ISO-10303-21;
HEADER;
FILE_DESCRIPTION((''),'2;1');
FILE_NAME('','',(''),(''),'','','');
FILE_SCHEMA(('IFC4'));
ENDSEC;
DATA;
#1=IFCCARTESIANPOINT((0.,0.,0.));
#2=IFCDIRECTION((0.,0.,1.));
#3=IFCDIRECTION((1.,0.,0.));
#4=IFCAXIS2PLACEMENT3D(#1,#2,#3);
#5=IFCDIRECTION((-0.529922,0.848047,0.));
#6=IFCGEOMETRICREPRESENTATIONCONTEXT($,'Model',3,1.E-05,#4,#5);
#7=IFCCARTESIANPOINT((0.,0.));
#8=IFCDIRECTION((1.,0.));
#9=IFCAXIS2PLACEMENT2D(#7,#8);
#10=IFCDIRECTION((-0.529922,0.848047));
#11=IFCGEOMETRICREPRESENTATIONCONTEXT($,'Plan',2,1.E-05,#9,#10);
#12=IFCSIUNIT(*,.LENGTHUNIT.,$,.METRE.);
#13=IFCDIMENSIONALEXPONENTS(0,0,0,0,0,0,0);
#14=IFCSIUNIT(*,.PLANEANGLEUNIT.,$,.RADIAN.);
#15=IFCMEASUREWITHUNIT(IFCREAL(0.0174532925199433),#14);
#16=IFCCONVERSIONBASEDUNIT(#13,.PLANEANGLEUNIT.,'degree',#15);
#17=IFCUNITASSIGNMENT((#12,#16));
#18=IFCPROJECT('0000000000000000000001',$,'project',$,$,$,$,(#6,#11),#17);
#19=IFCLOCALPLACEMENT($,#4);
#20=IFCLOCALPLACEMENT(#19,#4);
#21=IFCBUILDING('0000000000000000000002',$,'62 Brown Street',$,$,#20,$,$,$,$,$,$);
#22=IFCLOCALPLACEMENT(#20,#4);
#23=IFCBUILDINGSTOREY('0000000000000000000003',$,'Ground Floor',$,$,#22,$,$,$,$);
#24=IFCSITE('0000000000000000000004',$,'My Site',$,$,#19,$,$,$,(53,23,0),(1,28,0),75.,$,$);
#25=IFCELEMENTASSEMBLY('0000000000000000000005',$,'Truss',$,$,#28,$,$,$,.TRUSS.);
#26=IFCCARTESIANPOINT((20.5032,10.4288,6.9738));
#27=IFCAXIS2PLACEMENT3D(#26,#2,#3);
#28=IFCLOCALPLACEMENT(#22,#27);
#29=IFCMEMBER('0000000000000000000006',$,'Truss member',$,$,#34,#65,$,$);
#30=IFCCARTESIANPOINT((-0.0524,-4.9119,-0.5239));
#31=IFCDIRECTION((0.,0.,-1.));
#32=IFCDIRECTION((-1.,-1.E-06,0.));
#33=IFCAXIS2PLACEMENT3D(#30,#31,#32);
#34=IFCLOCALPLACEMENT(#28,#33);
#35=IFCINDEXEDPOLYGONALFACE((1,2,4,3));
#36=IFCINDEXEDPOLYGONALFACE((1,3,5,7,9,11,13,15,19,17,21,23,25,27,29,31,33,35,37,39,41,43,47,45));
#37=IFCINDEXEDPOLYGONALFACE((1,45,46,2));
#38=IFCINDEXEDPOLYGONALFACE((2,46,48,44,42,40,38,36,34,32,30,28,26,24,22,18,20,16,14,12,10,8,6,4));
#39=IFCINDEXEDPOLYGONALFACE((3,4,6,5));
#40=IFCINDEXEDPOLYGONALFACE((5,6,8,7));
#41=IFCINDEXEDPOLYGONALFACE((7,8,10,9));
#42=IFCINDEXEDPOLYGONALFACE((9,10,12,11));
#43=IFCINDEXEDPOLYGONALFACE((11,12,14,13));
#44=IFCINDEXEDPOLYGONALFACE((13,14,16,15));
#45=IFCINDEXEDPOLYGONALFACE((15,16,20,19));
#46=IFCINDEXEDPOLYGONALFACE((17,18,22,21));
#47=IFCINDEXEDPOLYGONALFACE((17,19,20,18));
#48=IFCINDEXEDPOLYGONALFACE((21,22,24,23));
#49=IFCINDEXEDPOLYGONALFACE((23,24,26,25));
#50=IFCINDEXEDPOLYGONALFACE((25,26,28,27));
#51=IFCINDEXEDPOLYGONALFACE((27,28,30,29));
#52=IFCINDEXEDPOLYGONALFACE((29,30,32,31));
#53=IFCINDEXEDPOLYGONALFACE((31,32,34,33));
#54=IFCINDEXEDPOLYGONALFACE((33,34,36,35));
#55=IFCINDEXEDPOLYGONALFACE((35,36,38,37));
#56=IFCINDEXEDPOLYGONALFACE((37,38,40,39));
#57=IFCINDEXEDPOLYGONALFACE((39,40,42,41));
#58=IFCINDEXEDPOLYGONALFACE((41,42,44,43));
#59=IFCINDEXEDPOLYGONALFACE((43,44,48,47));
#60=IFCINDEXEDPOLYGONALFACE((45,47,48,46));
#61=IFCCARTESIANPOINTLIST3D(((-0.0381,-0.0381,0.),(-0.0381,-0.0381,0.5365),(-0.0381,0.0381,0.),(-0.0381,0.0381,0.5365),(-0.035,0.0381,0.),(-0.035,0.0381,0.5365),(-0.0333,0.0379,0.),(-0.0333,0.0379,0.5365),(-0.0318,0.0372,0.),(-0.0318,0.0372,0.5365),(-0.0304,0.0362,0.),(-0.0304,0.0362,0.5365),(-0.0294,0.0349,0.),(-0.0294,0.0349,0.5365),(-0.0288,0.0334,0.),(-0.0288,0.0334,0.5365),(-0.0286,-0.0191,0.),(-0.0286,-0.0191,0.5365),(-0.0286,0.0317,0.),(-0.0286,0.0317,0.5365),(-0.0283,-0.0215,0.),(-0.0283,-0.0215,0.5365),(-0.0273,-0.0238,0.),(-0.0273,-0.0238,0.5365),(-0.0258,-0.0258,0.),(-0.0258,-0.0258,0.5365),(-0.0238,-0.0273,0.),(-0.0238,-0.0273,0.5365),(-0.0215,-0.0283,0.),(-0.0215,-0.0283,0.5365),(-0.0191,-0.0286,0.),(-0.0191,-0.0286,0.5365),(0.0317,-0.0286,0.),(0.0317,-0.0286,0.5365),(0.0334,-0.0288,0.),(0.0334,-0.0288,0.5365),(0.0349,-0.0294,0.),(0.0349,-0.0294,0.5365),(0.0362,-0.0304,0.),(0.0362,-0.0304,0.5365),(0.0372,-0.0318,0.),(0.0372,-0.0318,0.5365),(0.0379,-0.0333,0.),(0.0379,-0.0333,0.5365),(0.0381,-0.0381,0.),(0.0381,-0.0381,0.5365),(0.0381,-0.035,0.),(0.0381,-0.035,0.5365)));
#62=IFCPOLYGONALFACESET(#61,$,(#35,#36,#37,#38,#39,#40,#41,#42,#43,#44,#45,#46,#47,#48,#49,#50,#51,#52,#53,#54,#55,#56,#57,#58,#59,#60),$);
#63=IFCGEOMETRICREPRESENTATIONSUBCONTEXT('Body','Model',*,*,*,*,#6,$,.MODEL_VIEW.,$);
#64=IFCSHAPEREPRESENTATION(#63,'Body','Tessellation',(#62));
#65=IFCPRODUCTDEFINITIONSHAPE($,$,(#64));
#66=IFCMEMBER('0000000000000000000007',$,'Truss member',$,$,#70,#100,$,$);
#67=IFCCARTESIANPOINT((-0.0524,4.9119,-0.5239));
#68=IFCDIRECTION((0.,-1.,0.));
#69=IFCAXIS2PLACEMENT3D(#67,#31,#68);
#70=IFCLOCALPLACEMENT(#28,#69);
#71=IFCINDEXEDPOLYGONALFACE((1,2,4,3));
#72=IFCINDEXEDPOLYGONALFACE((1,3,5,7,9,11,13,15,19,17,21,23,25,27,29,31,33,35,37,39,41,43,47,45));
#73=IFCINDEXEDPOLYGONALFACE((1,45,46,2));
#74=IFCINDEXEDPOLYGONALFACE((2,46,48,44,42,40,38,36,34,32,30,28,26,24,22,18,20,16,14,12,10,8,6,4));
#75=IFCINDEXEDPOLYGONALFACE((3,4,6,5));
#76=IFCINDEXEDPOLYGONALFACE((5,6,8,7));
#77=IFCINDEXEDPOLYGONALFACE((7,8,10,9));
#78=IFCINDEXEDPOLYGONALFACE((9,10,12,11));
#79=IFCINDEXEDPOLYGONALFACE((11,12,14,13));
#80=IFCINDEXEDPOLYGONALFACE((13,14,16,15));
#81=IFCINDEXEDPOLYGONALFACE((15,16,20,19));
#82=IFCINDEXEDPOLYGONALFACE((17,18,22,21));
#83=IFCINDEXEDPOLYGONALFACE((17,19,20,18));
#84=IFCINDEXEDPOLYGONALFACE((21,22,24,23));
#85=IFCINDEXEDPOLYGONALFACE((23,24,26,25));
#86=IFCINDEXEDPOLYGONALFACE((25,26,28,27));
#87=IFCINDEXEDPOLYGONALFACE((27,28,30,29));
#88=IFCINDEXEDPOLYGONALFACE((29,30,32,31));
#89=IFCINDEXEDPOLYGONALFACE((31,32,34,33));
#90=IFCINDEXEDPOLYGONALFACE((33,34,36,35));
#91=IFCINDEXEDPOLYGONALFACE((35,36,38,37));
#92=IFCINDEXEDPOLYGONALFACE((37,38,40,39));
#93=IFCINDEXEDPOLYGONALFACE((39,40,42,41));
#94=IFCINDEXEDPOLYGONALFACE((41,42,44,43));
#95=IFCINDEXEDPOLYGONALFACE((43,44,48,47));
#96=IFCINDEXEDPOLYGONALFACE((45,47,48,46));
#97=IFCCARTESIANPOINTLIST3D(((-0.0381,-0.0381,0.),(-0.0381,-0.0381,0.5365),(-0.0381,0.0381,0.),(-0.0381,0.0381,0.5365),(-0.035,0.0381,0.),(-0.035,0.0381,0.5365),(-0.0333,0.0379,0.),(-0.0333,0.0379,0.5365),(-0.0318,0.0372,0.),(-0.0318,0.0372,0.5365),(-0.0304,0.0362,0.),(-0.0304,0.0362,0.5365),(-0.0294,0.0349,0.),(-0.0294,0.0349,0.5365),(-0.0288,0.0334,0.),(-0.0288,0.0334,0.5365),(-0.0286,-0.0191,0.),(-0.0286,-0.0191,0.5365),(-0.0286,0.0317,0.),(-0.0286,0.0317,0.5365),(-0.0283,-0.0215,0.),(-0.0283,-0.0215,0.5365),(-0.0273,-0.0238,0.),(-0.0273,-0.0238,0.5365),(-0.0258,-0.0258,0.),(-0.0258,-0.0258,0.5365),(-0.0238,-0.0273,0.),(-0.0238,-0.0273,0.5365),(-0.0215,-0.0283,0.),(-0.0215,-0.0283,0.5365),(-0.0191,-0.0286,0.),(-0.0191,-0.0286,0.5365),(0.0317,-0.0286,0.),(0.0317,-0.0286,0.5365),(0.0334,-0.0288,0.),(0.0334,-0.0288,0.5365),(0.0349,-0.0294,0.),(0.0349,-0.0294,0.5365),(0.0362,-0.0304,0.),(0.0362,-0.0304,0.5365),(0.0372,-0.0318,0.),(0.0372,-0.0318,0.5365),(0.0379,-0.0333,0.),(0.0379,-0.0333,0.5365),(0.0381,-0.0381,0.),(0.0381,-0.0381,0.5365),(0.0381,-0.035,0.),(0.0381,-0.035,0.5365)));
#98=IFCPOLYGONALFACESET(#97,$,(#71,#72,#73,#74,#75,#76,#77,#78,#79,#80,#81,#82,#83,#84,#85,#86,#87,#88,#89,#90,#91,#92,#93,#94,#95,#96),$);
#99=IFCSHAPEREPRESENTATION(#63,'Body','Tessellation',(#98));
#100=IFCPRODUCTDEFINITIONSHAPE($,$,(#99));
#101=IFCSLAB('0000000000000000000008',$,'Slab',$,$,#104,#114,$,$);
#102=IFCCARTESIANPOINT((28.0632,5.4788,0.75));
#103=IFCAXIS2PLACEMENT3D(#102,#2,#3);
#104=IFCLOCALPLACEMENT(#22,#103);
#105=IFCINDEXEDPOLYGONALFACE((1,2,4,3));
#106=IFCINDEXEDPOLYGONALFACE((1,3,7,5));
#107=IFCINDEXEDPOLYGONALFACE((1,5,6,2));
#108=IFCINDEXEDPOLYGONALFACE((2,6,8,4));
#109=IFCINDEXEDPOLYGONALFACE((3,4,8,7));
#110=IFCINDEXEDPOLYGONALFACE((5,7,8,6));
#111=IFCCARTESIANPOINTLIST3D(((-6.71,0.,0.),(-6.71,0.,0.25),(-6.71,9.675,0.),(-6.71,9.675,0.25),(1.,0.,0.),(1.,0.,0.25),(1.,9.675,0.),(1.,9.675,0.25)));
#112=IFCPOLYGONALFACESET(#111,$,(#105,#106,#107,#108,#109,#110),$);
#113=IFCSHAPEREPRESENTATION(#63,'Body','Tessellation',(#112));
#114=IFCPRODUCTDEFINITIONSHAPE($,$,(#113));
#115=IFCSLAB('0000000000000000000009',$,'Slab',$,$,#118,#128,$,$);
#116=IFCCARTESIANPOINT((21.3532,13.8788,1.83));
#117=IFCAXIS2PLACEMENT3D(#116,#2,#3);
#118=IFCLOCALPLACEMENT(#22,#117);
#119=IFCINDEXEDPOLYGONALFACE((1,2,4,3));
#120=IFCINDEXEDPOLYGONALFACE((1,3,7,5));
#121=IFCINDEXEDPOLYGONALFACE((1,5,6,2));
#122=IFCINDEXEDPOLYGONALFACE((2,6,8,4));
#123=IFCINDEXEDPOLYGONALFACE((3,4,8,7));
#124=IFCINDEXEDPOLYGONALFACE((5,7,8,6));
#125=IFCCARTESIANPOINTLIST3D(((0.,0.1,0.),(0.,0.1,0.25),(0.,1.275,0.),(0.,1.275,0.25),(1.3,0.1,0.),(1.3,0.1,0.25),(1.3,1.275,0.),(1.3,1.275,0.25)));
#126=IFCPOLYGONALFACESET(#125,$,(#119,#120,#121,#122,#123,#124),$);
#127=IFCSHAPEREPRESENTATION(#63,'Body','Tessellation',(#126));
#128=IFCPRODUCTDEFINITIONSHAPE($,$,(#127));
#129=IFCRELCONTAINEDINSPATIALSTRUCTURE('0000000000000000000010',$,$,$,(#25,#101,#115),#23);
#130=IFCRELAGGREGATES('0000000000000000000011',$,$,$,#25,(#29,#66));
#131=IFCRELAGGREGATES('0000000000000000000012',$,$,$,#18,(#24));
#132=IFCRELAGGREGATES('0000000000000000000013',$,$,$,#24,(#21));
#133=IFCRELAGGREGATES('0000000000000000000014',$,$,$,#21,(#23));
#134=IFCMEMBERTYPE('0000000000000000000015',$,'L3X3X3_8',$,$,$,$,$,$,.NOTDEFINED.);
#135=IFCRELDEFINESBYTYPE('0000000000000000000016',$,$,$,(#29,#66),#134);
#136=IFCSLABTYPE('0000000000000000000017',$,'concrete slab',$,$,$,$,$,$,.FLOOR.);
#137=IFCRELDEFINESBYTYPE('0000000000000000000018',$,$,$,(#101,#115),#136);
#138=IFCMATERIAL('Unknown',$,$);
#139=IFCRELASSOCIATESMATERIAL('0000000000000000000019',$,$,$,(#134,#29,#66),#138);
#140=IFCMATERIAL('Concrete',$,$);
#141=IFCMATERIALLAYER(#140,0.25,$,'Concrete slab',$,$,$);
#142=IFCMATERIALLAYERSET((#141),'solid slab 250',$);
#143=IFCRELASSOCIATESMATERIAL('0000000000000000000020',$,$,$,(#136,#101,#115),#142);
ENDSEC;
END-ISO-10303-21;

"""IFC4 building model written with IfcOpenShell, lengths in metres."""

from ifc_helpers import new_model, entity, si_unit, converted_unit, direction, frame, origin_with_axes, origin_2d_with_axis, place, context, subcontext, project, spatial, indexed_curve, l_section, outline, extrude, material, layer, layer_set, layer_usage, material_profile, profile_set, profile_usage, type_object, element, aggregate, save


model = new_model("IFC4")

# Units and contexts
model_context = context("Model", 3, precision=1e-05, world=origin_with_axes(), true_north=direction((-0.529922, 0.848047, 0.0)))
plan_context = context("Plan", 2, precision=1e-05, world=origin_2d_with_axis(), true_north=direction((-0.529922, 0.848047)))
body_context = subcontext(model_context, "Body", "Model", "MODEL_VIEW")
ifc_project = project(units=[si_unit("LENGTHUNIT", "METRE"), converted_unit("PLANEANGLEUNIT", "degree", entity("IfcReal", 0.0174532925199433), si_unit("PLANEANGLEUNIT", "RADIAN"), dimensions=[0, 0, 0, 0, 0, 0, 0])], contexts=[model_context, plan_context])

# Site, building, storey
site_placement = place(None, origin_with_axes())
site = spatial("IfcSite", under=ifc_project, at=site_placement, Name="My Site", RefLatitude=(53, 23, 0), RefLongitude=(1, 28, 0), RefElevation=75.0)
building_placement = place(site_placement, origin_with_axes())
building = spatial("IfcBuilding", under=site, at=building_placement, Name="62 Brown Street")
storey_placement = place(building_placement, origin_with_axes())
storey = spatial("IfcBuildingStorey", under=building, at=storey_placement, Name="Ground Floor")

# Shared definitions
ifc_material_1 = material(Name="Concrete")

# Element assembly, members
assembly_placement = place(storey_placement, frame((20.5032, 10.4288, 6.9738), z_axis=(0.0, 0.0, 1.0), x_axis=(1.0, 0.0, 0.0)))
assembly = element("IfcElementAssembly", 1, at=assembly_placement, inside=storey, Name="Truss", PredefinedType="TRUSS")
ifc_material_2 = material(Name="Unknown")
ifc_material_profile_1 = material_profile(ifc_material_2, l_section(Depth=0.0762, Width=0.0762, Thickness=0.0095, FilletRadius=0.0095, EdgeRadius=0.0064))
ifc_profile_set_1 = profile_set([ifc_material_profile_1])
member_type_1 = type_object("IfcMemberType", Name="L3X3X3_8", PredefinedType="NOTDEFINED", material=ifc_profile_set_1)
ifc_profile_usage_1 = profile_usage(ifc_profile_set_1, cardinal=5)
member_1_placement = place(assembly_placement, frame((-0.0524, -4.9119, -0.5239), z_axis=(0.0, 0.0, -1.0), x_axis=(-1.0, -0.000001, 0.0)))
member_1 = element("IfcMember", 2, at=member_1_placement, type_object=member_type_1, material=ifc_profile_usage_1, Name="Truss member", context=body_context, shape_type="SweptSolid", body=[
    extrude(l_section(Depth=0.0762, Width=0.0762, Thickness=0.0095, FilletRadius=0.0095, EdgeRadius=0.0064), origin_with_axes(), (0.0, 0.0, 1.0), 0.5365),
])
ifc_profile_usage_2 = profile_usage(ifc_profile_set_1, cardinal=5)
member_2_placement = place(assembly_placement, frame((-0.0524, 4.9119, -0.5239), z_axis=(0.0, 0.0, -1.0), x_axis=(0.0, -1.0, 0.0)))
member_2 = element("IfcMember", 3, at=member_2_placement, type_object=member_type_1, material=ifc_profile_usage_2, Name="Truss member", context=body_context, shape_type="SweptSolid", body=[
    extrude(l_section(Depth=0.0762, Width=0.0762, Thickness=0.0095, FilletRadius=0.0095, EdgeRadius=0.0064), origin_with_axes(), (0.0, 0.0, 1.0), 0.5365),
])
aggregate(assembly, [member_1, member_2])

# Slabs
ifc_layer_1 = layer(ifc_material_1, 0.25, Name="Concrete slab")
ifc_layer_set_1 = layer_set([ifc_layer_1], Name="solid slab 250")
slab_type = type_object("IfcSlabType", Name="concrete slab", PredefinedType="FLOOR", material=ifc_layer_set_1)
ifc_layer_usage_1 = layer_usage(ifc_layer_set_1, "AXIS3", "POSITIVE", 0.0)
slab_1_placement = place(storey_placement, frame((28.0632, 5.4788, 0.75), z_axis=(0.0, 0.0, 1.0), x_axis=(1.0, 0.0, 0.0)))
element("IfcSlab", 4, at=slab_1_placement, inside=storey, type_object=slab_type, material=ifc_layer_usage_1, Name="Slab", context=body_context, shape_type="SweptSolid", body=[
    extrude(outline(indexed_curve([(-6.71, 0.0), (-6.71, 9.675), (1.0, 9.675), (1.0, 0.0), (-6.71, 0.0)])), None, (0.0, 0.0, 1.0), 0.25),
])
ifc_layer_usage_2 = layer_usage(ifc_layer_set_1, "AXIS3", "POSITIVE", 0.0)
slab_2_placement = place(storey_placement, frame((21.3532, 13.8788, 1.83), z_axis=(0.0, 0.0, 1.0), x_axis=(1.0, 0.0, 0.0)))
element("IfcSlab", 5, at=slab_2_placement, inside=storey, type_object=slab_type, material=ifc_layer_usage_2, Name="Slab", context=body_context, shape_type="SweptSolid", body=[
    extrude(outline(indexed_curve([(0.0, 0.1), (1.3, 0.1), (1.3, 1.275), (0.0, 1.275), (0.0, 0.1)])), None, (0.0, 0.0, 1.0), 0.25),
])

save(model, "model.ifc")
